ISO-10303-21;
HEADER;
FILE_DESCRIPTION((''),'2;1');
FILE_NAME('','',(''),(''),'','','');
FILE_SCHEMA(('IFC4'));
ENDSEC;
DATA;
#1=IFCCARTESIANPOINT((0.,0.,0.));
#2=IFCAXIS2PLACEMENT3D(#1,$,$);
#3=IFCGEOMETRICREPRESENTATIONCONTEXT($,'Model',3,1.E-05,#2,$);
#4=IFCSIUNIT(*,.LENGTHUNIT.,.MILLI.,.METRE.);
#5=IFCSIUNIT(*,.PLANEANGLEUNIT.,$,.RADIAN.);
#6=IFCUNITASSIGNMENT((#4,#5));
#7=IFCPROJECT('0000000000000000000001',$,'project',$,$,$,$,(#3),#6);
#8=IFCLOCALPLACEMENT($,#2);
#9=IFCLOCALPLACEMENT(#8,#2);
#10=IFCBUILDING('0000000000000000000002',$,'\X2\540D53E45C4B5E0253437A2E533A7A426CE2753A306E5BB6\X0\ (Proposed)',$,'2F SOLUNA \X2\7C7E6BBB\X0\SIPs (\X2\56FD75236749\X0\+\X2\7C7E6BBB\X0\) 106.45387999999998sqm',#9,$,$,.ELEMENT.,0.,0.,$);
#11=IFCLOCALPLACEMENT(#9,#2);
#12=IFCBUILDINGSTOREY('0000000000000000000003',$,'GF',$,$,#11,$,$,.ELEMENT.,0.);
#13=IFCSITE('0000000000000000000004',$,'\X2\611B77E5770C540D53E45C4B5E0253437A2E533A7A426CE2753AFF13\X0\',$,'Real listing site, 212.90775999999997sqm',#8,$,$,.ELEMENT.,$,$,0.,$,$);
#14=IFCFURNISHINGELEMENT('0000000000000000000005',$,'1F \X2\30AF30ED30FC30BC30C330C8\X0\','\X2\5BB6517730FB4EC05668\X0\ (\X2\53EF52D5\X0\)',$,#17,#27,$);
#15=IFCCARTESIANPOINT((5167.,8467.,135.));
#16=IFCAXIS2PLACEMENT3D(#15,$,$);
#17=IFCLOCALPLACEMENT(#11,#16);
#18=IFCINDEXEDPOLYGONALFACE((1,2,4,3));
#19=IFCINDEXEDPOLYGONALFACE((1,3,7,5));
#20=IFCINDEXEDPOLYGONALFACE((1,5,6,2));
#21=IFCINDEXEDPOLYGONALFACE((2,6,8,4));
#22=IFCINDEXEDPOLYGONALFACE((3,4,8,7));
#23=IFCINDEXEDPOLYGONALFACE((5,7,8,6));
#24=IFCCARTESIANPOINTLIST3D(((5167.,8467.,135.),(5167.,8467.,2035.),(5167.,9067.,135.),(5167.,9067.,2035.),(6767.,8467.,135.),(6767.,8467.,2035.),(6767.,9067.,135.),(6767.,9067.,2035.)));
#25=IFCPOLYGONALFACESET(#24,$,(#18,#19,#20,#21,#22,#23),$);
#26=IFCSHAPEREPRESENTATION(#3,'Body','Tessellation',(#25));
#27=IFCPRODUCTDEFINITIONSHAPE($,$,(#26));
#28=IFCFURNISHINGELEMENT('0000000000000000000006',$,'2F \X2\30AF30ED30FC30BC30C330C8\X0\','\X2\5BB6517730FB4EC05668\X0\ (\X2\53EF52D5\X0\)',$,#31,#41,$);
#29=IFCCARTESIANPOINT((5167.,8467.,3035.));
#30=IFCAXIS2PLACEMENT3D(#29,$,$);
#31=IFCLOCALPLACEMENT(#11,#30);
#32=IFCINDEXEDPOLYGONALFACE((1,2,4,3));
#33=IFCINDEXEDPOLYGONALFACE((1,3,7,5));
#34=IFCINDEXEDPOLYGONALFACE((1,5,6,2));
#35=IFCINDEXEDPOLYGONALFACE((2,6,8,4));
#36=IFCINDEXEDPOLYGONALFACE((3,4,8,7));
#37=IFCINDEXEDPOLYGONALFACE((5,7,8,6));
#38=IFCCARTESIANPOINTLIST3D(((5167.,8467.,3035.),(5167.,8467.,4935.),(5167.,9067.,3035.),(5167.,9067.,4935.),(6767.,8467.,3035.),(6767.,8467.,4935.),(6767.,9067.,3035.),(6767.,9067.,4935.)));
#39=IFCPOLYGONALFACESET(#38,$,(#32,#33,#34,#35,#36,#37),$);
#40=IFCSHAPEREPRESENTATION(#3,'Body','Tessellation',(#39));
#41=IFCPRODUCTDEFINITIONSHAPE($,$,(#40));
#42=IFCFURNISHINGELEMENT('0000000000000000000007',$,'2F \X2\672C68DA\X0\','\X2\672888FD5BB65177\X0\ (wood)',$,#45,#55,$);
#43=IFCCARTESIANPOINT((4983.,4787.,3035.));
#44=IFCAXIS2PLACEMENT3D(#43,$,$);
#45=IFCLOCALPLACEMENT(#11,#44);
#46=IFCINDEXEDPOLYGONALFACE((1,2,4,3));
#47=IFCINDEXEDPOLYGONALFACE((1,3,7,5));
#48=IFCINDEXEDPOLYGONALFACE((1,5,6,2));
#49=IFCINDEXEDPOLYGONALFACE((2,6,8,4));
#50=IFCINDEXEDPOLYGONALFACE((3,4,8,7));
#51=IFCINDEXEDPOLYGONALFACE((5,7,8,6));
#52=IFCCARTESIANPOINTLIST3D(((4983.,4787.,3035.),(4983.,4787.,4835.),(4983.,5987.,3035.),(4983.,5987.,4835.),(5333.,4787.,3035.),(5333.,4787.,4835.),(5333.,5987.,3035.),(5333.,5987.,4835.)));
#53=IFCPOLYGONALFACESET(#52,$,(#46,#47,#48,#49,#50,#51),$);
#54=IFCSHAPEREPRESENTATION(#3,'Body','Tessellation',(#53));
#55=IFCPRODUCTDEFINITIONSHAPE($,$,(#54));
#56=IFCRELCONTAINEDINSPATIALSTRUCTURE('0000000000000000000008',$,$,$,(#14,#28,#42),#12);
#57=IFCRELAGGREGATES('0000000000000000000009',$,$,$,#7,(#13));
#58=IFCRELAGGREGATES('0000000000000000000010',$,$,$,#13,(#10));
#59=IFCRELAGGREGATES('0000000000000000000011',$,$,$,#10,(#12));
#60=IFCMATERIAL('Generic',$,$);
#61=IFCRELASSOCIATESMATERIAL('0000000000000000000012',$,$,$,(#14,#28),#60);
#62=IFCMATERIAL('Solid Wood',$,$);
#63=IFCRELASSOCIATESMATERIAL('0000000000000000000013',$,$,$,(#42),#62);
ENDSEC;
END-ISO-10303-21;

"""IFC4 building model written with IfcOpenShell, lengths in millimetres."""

from ifc_helpers import new_model, si_unit, frame, frame_2d, origin, place, context, project, spatial, rectangle, extrude, material, element, save


model = new_model("IFC4")

# Units and contexts
model_context = context("Model", 3, precision=1e-05, world=origin())
ifc_project = project(units=[si_unit("LENGTHUNIT", "METRE", prefix="MILLI"), si_unit("PLANEANGLEUNIT", "RADIAN")], contexts=[model_context])

# Site, building, storey
site_placement = place(None, origin())
site = spatial("IfcSite", under=ifc_project, at=site_placement, Name="愛知県名古屋市千種区穂波町３", ObjectType="Real listing site, 212.90775999999997sqm", CompositionType="ELEMENT", RefElevation=0.0)
building_placement = place(site_placement, origin())
building = spatial("IfcBuilding", under=site, at=building_placement, Name="名古屋市千種区穂波町の家 (Proposed)", ObjectType="2F SOLUNA 籾殻SIPs (国産杉+籾殻) 106.45387999999998sqm", CompositionType="ELEMENT", ElevationOfRefHeight=0.0, ElevationOfTerrain=0.0)
storey_placement = place(building_placement, origin())
storey = spatial("IfcBuildingStorey", under=building, at=storey_placement, Name="GF", CompositionType="ELEMENT", Elevation=0.0)

# Shared definitions
ifc_material_1 = material(Name="Solid Wood")

# Shared definitions
ifc_material_2 = material(Name="Generic")

# Furnishing elements
furnishing_1_placement = place(storey_placement, frame((5167.0, 8467.0, 135.0)))
element("IfcFurnishingElement", 1, at=furnishing_1_placement, inside=storey, material=ifc_material_2, Name="1F クローゼット", Description="家具・什器 (可動)", context=model_context, shape_type="SweptSolid", body=[
    extrude(rectangle(XDim=1600.0, YDim=600.0, at=frame_2d((800.0, 300.0))), frame((5167.0, 8467.0, 135.0)), (0.0, 0.0, 1.0), 1900.0),
])
furnishing_2_placement = place(storey_placement, frame((5167.0, 8467.0, 3035.0)))
element("IfcFurnishingElement", 2, at=furnishing_2_placement, inside=storey, material=ifc_material_2, Name="2F クローゼット", Description="家具・什器 (可動)", context=model_context, shape_type="SweptSolid", body=[
    extrude(rectangle(XDim=1600.0, YDim=600.0, at=frame_2d((800.0, 300.0))), frame((5167.0, 8467.0, 3035.0)), (0.0, 0.0, 1.0), 1900.0),
])
furnishing_3_placement = place(storey_placement, frame((4983.0, 4787.0, 3035.0)))
element("IfcFurnishingElement", 3, at=furnishing_3_placement, inside=storey, material=ifc_material_1, Name="2F 本棚", Description="木製家具 (wood)", context=model_context, shape_type="SweptSolid", body=[
    extrude(rectangle(XDim=350.0, YDim=1200.0, at=frame_2d((175.0, 600.0))), frame((4983.0, 4787.0, 3035.0)), (0.0, 0.0, 1.0), 1800.0),
])

save(model, "model.ifc")
